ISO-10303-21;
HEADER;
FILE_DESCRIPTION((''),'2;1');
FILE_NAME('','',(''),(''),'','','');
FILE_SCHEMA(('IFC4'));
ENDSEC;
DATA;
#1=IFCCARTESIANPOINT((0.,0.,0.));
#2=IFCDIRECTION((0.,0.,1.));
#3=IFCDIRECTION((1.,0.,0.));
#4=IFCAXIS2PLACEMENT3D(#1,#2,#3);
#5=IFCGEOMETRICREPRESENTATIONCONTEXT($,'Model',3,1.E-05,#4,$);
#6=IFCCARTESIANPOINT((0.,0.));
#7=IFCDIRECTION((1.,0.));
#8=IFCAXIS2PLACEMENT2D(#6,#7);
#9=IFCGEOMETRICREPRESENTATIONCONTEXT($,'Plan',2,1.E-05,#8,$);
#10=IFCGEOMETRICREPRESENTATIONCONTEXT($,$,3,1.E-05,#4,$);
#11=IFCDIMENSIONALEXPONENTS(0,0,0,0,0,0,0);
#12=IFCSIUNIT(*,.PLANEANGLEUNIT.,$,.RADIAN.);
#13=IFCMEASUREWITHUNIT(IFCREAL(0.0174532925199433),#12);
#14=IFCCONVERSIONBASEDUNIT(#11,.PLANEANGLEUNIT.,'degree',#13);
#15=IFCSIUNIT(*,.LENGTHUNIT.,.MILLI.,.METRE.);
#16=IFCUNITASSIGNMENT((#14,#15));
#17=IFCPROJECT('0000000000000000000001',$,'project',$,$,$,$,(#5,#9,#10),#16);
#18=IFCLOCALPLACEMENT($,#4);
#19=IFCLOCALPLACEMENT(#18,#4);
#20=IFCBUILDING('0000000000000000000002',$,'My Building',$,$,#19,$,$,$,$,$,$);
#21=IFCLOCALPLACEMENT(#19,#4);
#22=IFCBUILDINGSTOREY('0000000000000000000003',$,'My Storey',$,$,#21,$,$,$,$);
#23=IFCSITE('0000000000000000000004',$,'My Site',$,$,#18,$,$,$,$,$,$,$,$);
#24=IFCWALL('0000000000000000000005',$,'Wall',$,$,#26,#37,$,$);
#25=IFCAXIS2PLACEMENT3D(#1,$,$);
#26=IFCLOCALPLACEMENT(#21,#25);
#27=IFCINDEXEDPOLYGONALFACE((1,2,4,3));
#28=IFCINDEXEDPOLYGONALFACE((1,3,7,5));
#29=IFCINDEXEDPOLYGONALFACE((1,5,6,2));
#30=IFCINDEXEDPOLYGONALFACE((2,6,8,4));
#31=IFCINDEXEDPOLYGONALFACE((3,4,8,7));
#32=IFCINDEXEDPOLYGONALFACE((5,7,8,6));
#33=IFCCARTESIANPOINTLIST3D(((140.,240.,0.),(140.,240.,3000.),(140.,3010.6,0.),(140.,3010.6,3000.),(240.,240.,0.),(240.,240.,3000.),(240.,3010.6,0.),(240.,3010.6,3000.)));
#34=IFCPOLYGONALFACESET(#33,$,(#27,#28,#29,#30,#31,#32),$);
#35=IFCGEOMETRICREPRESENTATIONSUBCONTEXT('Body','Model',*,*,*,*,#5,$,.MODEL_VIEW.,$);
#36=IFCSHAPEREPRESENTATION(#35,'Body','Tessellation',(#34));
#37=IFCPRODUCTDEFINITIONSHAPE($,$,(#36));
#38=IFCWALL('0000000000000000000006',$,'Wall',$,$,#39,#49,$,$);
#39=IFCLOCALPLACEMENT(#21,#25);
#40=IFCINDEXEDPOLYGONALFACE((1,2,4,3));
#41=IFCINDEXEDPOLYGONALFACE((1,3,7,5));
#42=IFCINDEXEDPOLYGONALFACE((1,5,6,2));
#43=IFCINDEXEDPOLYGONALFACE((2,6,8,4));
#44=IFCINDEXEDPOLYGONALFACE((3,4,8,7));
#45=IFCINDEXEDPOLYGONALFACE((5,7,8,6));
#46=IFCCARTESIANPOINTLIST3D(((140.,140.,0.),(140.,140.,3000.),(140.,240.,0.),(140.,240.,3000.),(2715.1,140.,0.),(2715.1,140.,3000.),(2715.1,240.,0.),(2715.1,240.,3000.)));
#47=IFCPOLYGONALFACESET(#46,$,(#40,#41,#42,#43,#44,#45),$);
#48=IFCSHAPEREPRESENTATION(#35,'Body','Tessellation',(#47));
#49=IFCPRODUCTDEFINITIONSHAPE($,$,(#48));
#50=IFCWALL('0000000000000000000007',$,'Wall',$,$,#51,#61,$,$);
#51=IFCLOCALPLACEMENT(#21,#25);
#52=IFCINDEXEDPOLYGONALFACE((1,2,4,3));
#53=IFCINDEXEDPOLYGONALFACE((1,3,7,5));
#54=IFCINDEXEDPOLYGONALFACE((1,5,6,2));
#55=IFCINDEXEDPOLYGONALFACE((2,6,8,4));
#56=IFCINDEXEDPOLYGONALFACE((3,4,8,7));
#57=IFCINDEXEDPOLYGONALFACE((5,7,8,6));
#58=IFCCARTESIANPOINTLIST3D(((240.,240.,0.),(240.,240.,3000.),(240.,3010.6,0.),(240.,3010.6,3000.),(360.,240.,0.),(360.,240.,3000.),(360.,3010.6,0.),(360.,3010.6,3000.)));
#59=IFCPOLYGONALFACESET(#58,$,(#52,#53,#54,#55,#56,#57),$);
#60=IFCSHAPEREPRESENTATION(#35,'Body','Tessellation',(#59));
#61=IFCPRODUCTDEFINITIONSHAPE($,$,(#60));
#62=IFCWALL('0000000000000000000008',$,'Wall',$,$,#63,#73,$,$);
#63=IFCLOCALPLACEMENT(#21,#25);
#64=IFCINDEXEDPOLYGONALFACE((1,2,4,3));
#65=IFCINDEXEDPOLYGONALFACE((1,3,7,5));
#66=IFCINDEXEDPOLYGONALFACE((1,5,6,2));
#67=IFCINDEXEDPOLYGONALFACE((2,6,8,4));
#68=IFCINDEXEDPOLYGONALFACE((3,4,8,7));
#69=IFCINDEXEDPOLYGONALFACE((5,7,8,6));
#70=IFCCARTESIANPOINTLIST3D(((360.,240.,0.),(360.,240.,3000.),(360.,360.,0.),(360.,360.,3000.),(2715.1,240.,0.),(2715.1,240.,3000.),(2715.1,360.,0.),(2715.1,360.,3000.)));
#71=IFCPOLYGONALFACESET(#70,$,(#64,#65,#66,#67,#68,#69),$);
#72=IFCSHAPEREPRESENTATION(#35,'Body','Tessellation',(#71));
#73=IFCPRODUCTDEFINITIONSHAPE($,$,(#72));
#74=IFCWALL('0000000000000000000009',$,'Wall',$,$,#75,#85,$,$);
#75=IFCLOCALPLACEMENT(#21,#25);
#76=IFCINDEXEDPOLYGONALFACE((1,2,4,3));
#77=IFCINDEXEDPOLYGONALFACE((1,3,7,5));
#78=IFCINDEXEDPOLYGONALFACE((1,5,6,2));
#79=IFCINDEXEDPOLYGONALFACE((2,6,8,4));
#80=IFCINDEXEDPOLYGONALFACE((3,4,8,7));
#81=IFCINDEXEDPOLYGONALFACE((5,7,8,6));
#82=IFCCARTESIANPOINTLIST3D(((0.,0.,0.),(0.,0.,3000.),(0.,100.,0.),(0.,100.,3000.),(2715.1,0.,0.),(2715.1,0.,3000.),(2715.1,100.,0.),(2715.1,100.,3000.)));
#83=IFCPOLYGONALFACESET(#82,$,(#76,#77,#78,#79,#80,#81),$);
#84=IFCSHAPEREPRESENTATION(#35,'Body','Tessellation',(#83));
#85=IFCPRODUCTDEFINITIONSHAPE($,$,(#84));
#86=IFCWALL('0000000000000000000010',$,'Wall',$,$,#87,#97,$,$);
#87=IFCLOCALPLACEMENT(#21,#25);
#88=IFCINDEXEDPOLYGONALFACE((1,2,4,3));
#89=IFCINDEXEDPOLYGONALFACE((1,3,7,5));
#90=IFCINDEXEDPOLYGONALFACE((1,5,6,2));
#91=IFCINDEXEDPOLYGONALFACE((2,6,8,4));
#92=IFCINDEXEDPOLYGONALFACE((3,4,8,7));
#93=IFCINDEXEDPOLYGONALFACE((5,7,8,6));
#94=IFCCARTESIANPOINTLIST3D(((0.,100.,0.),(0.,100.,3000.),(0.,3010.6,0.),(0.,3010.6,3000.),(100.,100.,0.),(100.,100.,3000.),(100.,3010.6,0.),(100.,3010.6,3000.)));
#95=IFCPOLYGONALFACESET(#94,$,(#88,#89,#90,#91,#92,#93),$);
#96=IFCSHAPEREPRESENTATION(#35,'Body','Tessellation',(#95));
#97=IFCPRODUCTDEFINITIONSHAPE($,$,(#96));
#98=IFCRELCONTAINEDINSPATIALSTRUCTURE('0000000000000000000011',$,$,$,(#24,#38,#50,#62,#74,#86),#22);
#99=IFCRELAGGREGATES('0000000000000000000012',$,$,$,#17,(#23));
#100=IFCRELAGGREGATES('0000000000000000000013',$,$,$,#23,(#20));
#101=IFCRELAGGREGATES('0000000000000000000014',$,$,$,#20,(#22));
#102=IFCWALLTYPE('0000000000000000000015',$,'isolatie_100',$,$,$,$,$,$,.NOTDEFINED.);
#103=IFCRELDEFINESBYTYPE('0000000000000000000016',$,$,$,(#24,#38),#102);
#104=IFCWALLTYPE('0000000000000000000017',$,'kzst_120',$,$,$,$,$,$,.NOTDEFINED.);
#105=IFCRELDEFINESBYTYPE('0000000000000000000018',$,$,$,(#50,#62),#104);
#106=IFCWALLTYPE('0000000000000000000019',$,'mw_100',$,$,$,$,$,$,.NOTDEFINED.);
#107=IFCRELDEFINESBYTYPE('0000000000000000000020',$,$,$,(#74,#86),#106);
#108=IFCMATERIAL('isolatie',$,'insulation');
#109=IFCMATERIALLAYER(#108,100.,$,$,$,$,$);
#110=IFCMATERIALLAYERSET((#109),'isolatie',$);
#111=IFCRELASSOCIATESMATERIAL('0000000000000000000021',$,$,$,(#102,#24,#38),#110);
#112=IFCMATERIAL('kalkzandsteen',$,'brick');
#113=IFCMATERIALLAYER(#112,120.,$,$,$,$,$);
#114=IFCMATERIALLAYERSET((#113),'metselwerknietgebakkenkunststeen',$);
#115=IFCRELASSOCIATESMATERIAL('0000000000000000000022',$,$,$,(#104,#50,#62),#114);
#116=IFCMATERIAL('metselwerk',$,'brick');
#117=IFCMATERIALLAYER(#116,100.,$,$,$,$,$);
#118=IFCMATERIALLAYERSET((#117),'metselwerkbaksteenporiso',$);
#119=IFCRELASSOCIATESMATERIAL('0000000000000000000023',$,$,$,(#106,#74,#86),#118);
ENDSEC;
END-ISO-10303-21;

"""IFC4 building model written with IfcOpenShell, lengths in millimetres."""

from ifc_helpers import new_model, entity, si_unit, converted_unit, frame, origin_with_axes, origin_2d_with_axis, place, context, subcontext, project, spatial, indexed_curve, outline, extrude, material, layer, layer_set, layer_usage, type_object, element, save


model = new_model("IFC4")

# Units and contexts
model_context = context("Model", 3, precision=1e-05, world=origin_with_axes())
plan_context = context("Plan", 2, precision=1e-05, world=origin_2d_with_axis())
context_of_model = context(None, 3, precision=1e-05, world=origin_with_axes())
body_context = subcontext(model_context, "Body", "Model", "MODEL_VIEW")
ifc_project = project(units=[converted_unit("PLANEANGLEUNIT", "degree", entity("IfcReal", 0.0174532925199433), si_unit("PLANEANGLEUNIT", "RADIAN"), dimensions=[0, 0, 0, 0, 0, 0, 0]), si_unit("LENGTHUNIT", "METRE", prefix="MILLI")], contexts=[model_context, plan_context, context_of_model])

# Site, building, storey
site_placement = place(None, origin_with_axes())
site = spatial("IfcSite", under=ifc_project, at=site_placement, Name="My Site")
building_placement = place(site_placement, origin_with_axes())
building = spatial("IfcBuilding", under=site, at=building_placement, Name="My Building")
storey_placement = place(building_placement, origin_with_axes())
storey = spatial("IfcBuildingStorey", under=building, at=storey_placement, Name="My Storey")

# Walls
ifc_material_1 = material(Name="isolatie", Category="insulation")
ifc_layer_1 = layer(ifc_material_1, 100.0)
ifc_layer_set_1 = layer_set([ifc_layer_1], Name="isolatie")
ifc_layer_usage_1 = layer_usage(ifc_layer_set_1, "AXIS2", "POSITIVE", 0.0)
wall_type_1 = type_object("IfcWallType", Name="isolatie_100", PredefinedType="NOTDEFINED", material=ifc_layer_set_1)
wall_1_placement = place(storey_placement, frame((240.0, 240.0, 0.0), z_axis=(0.0, 0.0, 1.0), x_axis=(0.0, 1.0, 0.0)))
element("IfcWall", 1, at=wall_1_placement, inside=storey, type_object=wall_type_1, material=ifc_layer_usage_1, Name="Wall", context=body_context, shape_type="SweptSolid", body=[
    extrude(outline(indexed_curve([(0.0, 0.0), (0.0, 100.0), (2770.6, 100.0), (2770.6, 0.0), (0.0, 0.0)], self_intersect=False)), origin_with_axes(), (0.0, 0.0, 1.0), 3000.0),
])
ifc_layer_usage_2 = layer_usage(ifc_layer_set_1, "AXIS2", "POSITIVE", 0.0)
wall_2_placement = place(storey_placement, frame((140.0, 140.0, 0.0), z_axis=(0.0, 0.0, 1.0), x_axis=(1.0, 0.0, 0.0)))
element("IfcWall", 2, at=wall_2_placement, inside=storey, type_object=wall_type_1, material=ifc_layer_usage_2, Name="Wall", context=body_context, shape_type="SweptSolid", body=[
    extrude(outline(indexed_curve([(0.0, 0.0), (0.0, 100.0), (2575.1, 100.0), (2575.1, 0.0), (0.0, 0.0)], self_intersect=False)), origin_with_axes(), (0.0, 0.0, 1.0), 3000.0),
])
ifc_material_2 = material(Name="kalkzandsteen", Category="brick")
ifc_layer_2 = layer(ifc_material_2, 120.0)
ifc_layer_set_2 = layer_set([ifc_layer_2], Name="metselwerknietgebakkenkunststeen")
ifc_layer_usage_3 = layer_usage(ifc_layer_set_2, "AXIS2", "POSITIVE", 0.0)
wall_type_2 = type_object("IfcWallType", Name="kzst_120", PredefinedType="NOTDEFINED", material=ifc_layer_set_2)
wall_3_placement = place(storey_placement, frame((360.0, 240.0, 0.0), z_axis=(0.0, 0.0, 1.0), x_axis=(0.0, 1.0, 0.0)))
element("IfcWall", 3, at=wall_3_placement, inside=storey, type_object=wall_type_2, material=ifc_layer_usage_3, Name="Wall", context=body_context, shape_type="SweptSolid", body=[
    extrude(outline(indexed_curve([(0.0, 0.0), (0.0, 120.0), (2770.6, 120.0), (2770.6, 0.0), (0.0, 0.0)], self_intersect=False)), origin_with_axes(), (0.0, 0.0, 1.0), 3000.0),
])
ifc_layer_usage_4 = layer_usage(ifc_layer_set_2, "AXIS2", "POSITIVE", 0.0)
wall_4_placement = place(storey_placement, frame((360.0, 240.0, 0.0), z_axis=(0.0, 0.0, 1.0), x_axis=(1.0, 0.0, 0.0)))
element("IfcWall", 4, at=wall_4_placement, inside=storey, type_object=wall_type_2, material=ifc_layer_usage_4, Name="Wall", context=body_context, shape_type="SweptSolid", body=[
    extrude(outline(indexed_curve([(0.0, 0.0), (0.0, 120.0), (2355.1, 120.0), (2355.1, 0.0), (0.0, 0.0)], self_intersect=False)), origin_with_axes(), (0.0, 0.0, 1.0), 3000.0),
])
ifc_material_3 = material(Name="metselwerk", Category="brick")
ifc_layer_3 = layer(ifc_material_3, 100.0)
ifc_layer_set_3 = layer_set([ifc_layer_3], Name="metselwerkbaksteenporiso")
ifc_layer_usage_5 = layer_usage(ifc_layer_set_3, "AXIS2", "POSITIVE", 0.0)
wall_type_3 = type_object("IfcWallType", Name="mw_100", PredefinedType="NOTDEFINED", material=ifc_layer_set_3)
wall_5_placement = place(storey_placement, origin_with_axes())
element("IfcWall", 5, at=wall_5_placement, inside=storey, type_object=wall_type_3, material=ifc_layer_usage_5, Name="Wall", context=body_context, shape_type="SweptSolid", body=[
    extrude(outline(indexed_curve([(0.0, 0.0), (0.0, 100.0), (2715.1, 100.0), (2715.1, 0.0), (0.0, 0.0)], self_intersect=False)), origin_with_axes(), (0.0, 0.0, 1.0), 3000.0),
])
ifc_layer_usage_6 = layer_usage(ifc_layer_set_3, "AXIS2", "POSITIVE", 0.0)
wall_6_placement = place(storey_placement, frame((100.0, 100.0, 0.0), z_axis=(0.0, 0.0, 1.0), x_axis=(0.0, 1.0, 0.0)))
element("IfcWall", 6, at=wall_6_placement, inside=storey, type_object=wall_type_3, material=ifc_layer_usage_6, Name="Wall", context=body_context, shape_type="SweptSolid", body=[
    extrude(outline(indexed_curve([(0.0, 0.0), (0.0, 100.0), (2910.6, 100.0), (2910.6, 0.0), (0.0, 0.0)], self_intersect=False)), origin_with_axes(), (0.0, 0.0, 1.0), 3000.0),
])

save(model, "model.ifc")
